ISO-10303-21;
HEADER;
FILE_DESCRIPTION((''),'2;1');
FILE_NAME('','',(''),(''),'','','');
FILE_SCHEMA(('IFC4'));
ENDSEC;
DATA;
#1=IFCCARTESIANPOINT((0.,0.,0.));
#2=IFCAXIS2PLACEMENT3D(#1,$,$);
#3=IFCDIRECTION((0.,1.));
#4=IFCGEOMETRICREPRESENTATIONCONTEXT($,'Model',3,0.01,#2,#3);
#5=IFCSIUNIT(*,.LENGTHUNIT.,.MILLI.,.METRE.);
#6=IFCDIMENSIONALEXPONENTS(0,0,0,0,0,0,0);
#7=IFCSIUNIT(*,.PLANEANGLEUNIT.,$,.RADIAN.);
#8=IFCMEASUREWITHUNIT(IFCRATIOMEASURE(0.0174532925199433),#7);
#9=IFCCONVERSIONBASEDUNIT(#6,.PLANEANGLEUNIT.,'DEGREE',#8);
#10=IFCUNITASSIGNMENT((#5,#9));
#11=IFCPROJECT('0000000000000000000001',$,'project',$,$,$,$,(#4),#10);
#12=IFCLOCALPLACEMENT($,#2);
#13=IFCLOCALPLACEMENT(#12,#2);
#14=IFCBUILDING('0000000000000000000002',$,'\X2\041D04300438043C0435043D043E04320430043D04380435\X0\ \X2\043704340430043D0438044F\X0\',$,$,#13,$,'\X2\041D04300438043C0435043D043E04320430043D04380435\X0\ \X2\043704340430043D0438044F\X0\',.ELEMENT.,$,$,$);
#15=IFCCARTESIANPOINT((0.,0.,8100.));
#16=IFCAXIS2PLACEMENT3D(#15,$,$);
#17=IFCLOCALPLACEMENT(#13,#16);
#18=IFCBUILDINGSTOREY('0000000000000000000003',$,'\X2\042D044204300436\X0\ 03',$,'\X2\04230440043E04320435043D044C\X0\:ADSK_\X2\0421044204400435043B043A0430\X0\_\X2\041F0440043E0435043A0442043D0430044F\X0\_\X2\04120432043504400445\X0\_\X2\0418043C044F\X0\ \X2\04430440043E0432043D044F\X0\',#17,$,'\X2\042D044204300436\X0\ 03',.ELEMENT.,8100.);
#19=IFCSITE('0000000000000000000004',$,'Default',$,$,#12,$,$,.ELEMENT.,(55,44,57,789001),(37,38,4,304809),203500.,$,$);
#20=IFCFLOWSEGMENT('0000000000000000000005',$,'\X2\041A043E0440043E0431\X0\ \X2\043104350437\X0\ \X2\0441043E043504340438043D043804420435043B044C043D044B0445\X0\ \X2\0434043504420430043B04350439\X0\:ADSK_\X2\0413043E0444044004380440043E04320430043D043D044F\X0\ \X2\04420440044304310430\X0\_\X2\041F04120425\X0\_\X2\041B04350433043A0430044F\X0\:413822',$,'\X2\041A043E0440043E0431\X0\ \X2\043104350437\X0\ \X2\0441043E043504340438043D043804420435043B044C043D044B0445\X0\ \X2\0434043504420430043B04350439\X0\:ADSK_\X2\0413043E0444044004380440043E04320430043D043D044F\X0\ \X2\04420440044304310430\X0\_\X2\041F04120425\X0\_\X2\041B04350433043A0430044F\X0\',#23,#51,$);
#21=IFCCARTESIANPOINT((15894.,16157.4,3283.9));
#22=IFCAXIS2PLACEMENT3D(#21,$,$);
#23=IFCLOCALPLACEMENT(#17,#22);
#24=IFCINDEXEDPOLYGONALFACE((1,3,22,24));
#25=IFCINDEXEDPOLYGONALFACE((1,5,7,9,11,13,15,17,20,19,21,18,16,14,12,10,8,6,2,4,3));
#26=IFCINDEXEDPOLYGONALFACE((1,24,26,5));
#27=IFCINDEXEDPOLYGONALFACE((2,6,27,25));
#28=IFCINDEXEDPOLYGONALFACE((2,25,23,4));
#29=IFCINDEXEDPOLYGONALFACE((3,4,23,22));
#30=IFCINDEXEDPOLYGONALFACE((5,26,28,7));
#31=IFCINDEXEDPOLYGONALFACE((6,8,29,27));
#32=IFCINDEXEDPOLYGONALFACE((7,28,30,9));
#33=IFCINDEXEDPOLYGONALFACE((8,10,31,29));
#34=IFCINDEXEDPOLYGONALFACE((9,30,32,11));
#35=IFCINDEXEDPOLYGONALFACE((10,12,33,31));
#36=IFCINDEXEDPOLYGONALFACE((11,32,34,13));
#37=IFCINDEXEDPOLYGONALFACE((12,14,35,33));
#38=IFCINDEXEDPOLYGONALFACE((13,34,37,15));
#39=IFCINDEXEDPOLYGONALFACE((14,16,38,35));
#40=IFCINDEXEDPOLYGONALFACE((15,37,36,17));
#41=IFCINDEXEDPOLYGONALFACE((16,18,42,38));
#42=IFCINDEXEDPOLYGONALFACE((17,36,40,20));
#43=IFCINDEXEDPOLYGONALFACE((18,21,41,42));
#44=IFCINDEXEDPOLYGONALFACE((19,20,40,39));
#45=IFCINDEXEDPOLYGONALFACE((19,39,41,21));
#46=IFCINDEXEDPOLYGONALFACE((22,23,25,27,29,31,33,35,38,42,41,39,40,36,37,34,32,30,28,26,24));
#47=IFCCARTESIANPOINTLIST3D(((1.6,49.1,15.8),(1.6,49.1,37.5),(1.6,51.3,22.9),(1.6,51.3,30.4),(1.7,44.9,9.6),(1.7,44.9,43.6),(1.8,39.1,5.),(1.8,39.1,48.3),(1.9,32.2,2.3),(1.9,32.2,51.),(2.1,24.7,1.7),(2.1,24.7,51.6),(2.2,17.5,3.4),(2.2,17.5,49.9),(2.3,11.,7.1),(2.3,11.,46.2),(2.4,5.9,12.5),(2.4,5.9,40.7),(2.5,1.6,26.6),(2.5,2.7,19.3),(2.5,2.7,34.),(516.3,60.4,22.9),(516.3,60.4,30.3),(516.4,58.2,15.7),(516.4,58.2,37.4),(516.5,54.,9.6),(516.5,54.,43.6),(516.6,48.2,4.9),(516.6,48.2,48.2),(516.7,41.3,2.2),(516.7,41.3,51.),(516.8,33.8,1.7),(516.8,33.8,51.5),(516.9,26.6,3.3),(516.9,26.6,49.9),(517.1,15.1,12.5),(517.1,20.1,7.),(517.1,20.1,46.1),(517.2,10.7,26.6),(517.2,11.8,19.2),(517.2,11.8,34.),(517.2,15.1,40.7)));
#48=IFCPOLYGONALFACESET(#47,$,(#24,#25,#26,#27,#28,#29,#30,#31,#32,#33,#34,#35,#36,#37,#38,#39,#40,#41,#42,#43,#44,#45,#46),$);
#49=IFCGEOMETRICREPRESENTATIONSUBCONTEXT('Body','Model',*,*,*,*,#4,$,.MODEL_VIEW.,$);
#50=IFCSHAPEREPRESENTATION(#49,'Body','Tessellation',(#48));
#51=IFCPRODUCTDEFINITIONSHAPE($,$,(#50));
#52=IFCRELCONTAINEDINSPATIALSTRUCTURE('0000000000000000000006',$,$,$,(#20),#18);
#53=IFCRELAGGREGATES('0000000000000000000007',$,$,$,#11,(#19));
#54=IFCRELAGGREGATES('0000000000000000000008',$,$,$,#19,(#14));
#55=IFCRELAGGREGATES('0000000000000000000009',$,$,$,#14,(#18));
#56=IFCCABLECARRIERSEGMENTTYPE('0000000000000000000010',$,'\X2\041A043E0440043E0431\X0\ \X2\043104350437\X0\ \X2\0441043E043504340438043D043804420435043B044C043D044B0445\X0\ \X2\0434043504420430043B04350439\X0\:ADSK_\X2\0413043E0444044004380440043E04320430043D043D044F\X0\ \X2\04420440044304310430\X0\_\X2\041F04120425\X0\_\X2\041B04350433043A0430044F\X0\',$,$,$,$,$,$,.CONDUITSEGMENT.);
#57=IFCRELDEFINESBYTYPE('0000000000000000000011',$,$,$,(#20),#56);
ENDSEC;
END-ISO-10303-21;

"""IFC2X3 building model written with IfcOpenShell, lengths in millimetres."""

from ifc_helpers import new_model, entity, si_unit, converted_unit, direction, frame, frame_2d, origin, place, context, subcontext, project, spatial, circle, extrude, type_object, element, save


model = new_model("IFC2X3")

# Units and contexts
model_context = context("Model", 3, precision=0.01, world=origin(), true_north=direction((0.0, 1.0)))
body_context = subcontext(model_context, "Body", "Model", "MODEL_VIEW")
ifc_project = project(units=[si_unit("LENGTHUNIT", "METRE", prefix="MILLI"), converted_unit("PLANEANGLEUNIT", "DEGREE", entity("IfcRatioMeasure", 0.0174532925199433), si_unit("PLANEANGLEUNIT", "RADIAN"), dimensions=[0, 0, 0, 0, 0, 0, 0])], contexts=[model_context])

# Site, building, storey
site_placement = place(None, frame((0.0, 0.0, 0.0)))
site = spatial("IfcSite", under=ifc_project, at=site_placement, Name="Default", CompositionType="ELEMENT", RefLatitude=(55, 44, 57, 789001), RefLongitude=(37, 38, 4, 304809), RefElevation=203500.0)
building_placement = place(site_placement, origin())
building = spatial("IfcBuilding", under=site, at=building_placement, Name="Наименование здания", LongName="Наименование здания", CompositionType="ELEMENT")
storey_placement = place(building_placement, frame((0.0, 0.0, 8100.0)))
storey = spatial("IfcBuildingStorey", under=building, at=storey_placement, Name="Этаж 03", ObjectType="Уровень:ADSK_Стрелка_Проектная_Вверх_Имя уровня", LongName="Этаж 03", CompositionType="ELEMENT", Elevation=8100.0)

# Flow segment
cable_carrier_segment_type = type_object("IfcCableCarrierSegmentType", Name="Короб без соединительных деталей:ADSK_Гофрировання труба_ПВХ_Легкая", PredefinedType="CONDUITSEGMENT")
flow_segment_1_placement = place(storey_placement, frame((15894.0, 16157.4, 3283.9)))
element("IfcFlowSegment", 1, at=flow_segment_1_placement, inside=storey, type_object=cable_carrier_segment_type, Name="Короб без соединительных деталей:ADSK_Гофрировання труба_ПВХ_Легкая:413822", ObjectType="Короб без соединительных деталей:ADSK_Гофрировання труба_ПВХ_Легкая", context=body_context, shape_type="SweptSolid", body=[
    extrude(circle(Radius=25.0, at=frame_2d((0.0, 0.0), x_axis=(1.0, 0.0))), frame((516.8, 35.7, 26.6), z_axis=(-0.999843, -0.017709, 0.000064), x_axis=(0.017709, -0.999843, 0.0)), (0.0, 0.0, 1.0), 514.8),
])

save(model, "model.ifc")
